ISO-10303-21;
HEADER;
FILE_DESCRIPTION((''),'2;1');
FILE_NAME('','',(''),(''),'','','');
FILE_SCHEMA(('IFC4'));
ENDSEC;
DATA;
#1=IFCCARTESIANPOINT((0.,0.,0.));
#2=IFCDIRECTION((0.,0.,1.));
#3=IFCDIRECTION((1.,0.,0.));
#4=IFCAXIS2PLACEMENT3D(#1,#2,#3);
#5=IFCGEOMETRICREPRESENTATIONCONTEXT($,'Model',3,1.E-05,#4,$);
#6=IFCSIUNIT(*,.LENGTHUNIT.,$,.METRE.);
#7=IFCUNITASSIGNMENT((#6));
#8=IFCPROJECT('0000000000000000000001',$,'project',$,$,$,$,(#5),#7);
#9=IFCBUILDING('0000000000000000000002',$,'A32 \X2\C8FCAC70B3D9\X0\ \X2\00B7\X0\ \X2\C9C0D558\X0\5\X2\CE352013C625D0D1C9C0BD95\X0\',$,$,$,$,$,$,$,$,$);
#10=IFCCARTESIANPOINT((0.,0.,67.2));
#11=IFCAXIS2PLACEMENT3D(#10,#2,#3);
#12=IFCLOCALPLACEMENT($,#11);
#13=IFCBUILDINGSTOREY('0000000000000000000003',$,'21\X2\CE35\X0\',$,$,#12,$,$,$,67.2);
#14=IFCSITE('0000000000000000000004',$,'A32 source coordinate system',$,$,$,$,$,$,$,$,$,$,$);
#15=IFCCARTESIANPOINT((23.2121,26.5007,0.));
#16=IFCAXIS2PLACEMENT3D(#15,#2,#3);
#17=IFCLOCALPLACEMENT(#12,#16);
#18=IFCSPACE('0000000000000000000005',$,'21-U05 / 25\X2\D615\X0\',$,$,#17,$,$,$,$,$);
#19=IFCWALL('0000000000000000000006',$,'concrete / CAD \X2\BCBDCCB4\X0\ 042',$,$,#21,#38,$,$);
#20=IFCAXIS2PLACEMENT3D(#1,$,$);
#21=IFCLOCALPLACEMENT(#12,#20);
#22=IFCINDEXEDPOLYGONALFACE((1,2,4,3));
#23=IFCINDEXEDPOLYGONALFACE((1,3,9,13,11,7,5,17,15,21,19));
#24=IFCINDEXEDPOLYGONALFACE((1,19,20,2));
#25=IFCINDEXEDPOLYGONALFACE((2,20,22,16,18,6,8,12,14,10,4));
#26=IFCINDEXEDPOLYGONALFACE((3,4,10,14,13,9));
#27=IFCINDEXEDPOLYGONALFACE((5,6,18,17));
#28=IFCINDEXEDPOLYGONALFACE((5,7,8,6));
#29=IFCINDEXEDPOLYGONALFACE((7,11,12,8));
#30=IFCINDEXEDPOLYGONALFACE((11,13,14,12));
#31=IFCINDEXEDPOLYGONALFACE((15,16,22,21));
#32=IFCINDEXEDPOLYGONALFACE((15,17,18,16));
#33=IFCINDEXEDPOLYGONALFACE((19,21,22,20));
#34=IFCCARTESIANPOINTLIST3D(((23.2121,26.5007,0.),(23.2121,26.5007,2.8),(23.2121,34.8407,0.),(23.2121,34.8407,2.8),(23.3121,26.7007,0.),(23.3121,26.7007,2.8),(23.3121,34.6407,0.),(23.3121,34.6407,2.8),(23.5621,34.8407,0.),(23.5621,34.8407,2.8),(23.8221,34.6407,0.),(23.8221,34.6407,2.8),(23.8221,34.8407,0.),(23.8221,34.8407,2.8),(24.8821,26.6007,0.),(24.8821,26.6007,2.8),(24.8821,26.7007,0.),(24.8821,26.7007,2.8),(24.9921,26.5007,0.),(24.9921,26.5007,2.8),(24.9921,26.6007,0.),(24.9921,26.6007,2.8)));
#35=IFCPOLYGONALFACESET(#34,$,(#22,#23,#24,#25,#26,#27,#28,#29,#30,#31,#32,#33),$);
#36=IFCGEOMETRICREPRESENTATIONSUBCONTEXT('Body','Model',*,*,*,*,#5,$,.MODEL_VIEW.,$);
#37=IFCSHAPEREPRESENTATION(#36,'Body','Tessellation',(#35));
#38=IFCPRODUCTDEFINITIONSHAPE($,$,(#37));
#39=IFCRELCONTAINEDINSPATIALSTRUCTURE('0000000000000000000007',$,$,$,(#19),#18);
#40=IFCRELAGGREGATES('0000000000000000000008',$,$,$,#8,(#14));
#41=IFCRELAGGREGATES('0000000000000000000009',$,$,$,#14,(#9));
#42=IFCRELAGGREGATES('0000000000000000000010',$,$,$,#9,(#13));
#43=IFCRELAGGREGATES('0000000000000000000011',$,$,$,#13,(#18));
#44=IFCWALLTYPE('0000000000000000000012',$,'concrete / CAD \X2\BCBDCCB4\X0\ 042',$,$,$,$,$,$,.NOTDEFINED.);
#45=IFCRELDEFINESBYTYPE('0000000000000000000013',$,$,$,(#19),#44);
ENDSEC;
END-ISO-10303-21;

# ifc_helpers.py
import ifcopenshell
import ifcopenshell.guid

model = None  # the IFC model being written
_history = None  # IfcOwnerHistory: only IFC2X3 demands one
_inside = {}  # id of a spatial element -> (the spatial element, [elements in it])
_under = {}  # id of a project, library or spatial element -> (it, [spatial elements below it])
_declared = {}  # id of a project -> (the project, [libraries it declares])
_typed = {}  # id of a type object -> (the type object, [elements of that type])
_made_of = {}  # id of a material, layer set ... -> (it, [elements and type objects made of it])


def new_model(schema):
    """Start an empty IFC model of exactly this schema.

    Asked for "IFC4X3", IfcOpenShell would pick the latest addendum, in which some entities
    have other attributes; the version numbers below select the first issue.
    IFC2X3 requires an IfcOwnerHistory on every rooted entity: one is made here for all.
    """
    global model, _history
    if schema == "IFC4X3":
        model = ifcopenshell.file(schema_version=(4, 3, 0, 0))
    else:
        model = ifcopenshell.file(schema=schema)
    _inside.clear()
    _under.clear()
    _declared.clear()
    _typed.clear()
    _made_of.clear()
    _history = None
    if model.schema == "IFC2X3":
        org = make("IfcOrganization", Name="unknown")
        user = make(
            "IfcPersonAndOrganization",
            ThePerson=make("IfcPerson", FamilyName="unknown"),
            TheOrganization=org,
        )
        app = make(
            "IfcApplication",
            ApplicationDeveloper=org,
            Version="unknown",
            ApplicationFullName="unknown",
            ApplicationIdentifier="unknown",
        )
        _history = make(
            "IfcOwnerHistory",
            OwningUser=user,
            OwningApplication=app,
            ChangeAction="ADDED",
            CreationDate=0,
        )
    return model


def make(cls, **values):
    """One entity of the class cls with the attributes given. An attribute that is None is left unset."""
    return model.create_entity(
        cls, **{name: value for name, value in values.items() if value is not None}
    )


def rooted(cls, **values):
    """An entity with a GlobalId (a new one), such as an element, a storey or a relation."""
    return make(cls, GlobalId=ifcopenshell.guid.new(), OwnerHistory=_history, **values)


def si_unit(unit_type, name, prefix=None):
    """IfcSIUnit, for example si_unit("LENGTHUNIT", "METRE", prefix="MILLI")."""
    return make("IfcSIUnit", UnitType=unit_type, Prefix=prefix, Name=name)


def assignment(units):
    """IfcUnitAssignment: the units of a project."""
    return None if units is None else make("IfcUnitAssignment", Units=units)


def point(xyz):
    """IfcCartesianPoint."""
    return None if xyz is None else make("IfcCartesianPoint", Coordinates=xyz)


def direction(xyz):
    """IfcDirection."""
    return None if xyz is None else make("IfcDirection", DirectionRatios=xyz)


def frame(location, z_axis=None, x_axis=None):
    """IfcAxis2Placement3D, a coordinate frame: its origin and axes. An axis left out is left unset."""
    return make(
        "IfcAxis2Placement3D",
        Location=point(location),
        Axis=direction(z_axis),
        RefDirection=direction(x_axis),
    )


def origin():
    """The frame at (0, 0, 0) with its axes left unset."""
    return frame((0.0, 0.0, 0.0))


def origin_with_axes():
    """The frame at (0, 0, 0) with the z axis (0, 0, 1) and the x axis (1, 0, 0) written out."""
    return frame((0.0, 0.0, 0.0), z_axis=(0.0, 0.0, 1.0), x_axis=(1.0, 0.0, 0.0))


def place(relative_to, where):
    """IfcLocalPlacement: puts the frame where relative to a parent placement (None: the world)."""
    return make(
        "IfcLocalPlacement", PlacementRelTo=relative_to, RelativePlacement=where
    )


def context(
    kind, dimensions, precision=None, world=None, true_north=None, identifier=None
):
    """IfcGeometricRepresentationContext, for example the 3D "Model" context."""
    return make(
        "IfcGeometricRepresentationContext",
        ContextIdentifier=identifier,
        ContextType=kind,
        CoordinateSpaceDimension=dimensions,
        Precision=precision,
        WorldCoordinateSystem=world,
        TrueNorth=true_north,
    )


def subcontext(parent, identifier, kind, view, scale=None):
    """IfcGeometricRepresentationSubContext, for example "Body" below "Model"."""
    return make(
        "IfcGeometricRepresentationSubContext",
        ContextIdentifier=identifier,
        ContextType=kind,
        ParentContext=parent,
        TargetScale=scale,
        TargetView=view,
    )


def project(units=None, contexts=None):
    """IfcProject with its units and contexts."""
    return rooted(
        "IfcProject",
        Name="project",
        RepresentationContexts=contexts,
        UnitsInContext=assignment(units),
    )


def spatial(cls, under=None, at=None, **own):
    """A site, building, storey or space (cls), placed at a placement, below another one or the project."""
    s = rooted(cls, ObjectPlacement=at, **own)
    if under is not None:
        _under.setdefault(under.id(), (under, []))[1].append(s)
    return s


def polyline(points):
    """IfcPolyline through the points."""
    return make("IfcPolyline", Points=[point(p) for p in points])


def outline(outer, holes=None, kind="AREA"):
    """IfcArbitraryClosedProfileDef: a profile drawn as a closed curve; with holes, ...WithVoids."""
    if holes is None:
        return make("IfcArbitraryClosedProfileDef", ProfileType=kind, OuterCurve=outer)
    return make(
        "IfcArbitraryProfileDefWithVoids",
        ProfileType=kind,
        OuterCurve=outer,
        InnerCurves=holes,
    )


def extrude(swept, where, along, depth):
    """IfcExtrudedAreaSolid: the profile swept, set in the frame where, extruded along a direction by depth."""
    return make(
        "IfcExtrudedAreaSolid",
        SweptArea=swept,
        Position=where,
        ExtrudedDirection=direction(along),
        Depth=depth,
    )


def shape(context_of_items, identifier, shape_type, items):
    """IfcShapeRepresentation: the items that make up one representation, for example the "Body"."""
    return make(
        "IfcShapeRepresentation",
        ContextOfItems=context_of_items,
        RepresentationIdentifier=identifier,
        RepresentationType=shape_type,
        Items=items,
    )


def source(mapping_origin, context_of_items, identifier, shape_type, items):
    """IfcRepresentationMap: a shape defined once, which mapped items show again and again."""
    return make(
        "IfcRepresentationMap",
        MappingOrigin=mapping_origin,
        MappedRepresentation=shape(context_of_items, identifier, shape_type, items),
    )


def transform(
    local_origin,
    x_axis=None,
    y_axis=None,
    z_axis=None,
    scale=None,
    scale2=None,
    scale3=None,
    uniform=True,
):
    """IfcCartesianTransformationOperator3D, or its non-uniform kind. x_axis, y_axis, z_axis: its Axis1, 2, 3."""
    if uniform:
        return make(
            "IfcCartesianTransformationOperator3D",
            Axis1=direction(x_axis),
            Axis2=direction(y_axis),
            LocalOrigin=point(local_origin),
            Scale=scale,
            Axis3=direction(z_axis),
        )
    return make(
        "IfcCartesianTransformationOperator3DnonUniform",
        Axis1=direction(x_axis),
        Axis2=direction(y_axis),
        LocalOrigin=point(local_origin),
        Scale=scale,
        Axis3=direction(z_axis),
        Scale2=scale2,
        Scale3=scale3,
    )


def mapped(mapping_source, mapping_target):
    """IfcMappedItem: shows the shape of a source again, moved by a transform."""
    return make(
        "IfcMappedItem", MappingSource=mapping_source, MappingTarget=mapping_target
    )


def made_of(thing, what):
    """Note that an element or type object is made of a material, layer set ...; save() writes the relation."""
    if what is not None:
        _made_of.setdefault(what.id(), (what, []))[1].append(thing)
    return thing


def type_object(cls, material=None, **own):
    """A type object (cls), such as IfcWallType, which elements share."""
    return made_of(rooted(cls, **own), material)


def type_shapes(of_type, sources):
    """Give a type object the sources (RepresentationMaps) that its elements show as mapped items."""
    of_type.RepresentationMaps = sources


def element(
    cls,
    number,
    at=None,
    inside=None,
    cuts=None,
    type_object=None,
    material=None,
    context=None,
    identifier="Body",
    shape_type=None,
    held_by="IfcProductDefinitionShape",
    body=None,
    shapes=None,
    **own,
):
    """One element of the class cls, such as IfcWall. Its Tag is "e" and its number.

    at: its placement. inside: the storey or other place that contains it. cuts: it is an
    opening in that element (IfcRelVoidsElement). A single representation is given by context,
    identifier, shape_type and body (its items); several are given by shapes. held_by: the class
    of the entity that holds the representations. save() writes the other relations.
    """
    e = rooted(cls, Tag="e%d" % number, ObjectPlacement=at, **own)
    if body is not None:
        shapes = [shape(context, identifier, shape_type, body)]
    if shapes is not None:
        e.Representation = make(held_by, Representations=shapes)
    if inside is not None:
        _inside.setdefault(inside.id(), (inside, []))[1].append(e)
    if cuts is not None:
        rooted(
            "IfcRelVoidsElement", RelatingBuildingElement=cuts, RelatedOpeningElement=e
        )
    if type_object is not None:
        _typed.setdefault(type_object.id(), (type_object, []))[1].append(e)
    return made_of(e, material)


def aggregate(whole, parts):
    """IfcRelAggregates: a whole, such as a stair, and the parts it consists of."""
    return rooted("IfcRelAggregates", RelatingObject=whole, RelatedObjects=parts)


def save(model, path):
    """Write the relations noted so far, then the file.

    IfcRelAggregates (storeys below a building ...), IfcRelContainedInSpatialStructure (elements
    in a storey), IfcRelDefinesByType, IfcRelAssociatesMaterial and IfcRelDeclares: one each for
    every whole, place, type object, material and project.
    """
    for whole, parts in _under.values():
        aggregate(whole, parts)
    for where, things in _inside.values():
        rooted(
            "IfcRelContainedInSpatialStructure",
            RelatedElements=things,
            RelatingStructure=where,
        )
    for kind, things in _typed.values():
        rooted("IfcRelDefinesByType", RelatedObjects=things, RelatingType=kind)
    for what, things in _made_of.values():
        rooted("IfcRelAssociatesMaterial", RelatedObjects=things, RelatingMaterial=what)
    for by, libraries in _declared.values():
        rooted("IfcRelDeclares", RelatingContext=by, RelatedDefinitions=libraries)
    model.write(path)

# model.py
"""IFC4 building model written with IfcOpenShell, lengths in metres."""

from ifc_helpers import new_model, si_unit, frame, origin, origin_with_axes, place, context, subcontext, project, spatial, polyline, outline, extrude, source, transform, mapped, type_object, type_shapes, element, save


model = new_model("IFC4")

# Units and contexts
model_context = context("Model", 3, precision=1e-05, world=origin_with_axes())
body_context = subcontext(model_context, "Body", "Model", "MODEL_VIEW")
ifc_project = project(units=[si_unit("LENGTHUNIT", "METRE")], contexts=[model_context])

# Site, building, storey, space
site = spatial("IfcSite", under=ifc_project, Name="A32 source coordinate system")
building = spatial("IfcBuilding", under=site, Name="A32 주거동 · 지하5층–옥탑지붕")
storey_placement = place(None, frame((0.0, 0.0, 67.2), z_axis=(0.0, 0.0, 1.0), x_axis=(1.0, 0.0, 0.0)))
storey = spatial("IfcBuildingStorey", under=building, at=storey_placement, Name="21층", Elevation=67.2)
space_1_placement = place(storey_placement, frame((23.2121, 26.5007, 0.0), z_axis=(0.0, 0.0, 1.0), x_axis=(1.0, 0.0, 0.0)))
space_1 = spatial("IfcSpace", under=storey, at=space_1_placement, Name="21-U05 / 25형")

# Wall
wall_type_1 = type_object("IfcWallType", Name="concrete / CAD 벽체 042", PredefinedType="NOTDEFINED")
shared_shape_1 = source(origin(), body_context, "Body", "SweptSolid", [
    extrude(outline(polyline([(0.1, 8.14), (0.1, 0.2), (1.67, 0.2), (1.67, 0.1), (1.78, 0.1), (1.78, 0.0), (0.0, 0.0), (0.0, 8.34), (0.35, 8.34), (0.35, 8.34), (0.61, 8.34), (0.61, 8.14), (0.1, 8.14)])), origin(), (0.0, 0.0, 1.0), 2.8),
])
type_shapes(wall_type_1, [shared_shape_1])
wall_1_placement = place(space_1_placement, origin_with_axes())
element("IfcWall", 1, at=wall_1_placement, inside=space_1, type_object=wall_type_1, Name="concrete / CAD 벽체 042", context=body_context, shape_type="MappedRepresentation", body=[
    mapped(shared_shape_1, transform((0.0, 0.0, 0.0), scale=1.0)),
])

save(model, "model.ifc")
